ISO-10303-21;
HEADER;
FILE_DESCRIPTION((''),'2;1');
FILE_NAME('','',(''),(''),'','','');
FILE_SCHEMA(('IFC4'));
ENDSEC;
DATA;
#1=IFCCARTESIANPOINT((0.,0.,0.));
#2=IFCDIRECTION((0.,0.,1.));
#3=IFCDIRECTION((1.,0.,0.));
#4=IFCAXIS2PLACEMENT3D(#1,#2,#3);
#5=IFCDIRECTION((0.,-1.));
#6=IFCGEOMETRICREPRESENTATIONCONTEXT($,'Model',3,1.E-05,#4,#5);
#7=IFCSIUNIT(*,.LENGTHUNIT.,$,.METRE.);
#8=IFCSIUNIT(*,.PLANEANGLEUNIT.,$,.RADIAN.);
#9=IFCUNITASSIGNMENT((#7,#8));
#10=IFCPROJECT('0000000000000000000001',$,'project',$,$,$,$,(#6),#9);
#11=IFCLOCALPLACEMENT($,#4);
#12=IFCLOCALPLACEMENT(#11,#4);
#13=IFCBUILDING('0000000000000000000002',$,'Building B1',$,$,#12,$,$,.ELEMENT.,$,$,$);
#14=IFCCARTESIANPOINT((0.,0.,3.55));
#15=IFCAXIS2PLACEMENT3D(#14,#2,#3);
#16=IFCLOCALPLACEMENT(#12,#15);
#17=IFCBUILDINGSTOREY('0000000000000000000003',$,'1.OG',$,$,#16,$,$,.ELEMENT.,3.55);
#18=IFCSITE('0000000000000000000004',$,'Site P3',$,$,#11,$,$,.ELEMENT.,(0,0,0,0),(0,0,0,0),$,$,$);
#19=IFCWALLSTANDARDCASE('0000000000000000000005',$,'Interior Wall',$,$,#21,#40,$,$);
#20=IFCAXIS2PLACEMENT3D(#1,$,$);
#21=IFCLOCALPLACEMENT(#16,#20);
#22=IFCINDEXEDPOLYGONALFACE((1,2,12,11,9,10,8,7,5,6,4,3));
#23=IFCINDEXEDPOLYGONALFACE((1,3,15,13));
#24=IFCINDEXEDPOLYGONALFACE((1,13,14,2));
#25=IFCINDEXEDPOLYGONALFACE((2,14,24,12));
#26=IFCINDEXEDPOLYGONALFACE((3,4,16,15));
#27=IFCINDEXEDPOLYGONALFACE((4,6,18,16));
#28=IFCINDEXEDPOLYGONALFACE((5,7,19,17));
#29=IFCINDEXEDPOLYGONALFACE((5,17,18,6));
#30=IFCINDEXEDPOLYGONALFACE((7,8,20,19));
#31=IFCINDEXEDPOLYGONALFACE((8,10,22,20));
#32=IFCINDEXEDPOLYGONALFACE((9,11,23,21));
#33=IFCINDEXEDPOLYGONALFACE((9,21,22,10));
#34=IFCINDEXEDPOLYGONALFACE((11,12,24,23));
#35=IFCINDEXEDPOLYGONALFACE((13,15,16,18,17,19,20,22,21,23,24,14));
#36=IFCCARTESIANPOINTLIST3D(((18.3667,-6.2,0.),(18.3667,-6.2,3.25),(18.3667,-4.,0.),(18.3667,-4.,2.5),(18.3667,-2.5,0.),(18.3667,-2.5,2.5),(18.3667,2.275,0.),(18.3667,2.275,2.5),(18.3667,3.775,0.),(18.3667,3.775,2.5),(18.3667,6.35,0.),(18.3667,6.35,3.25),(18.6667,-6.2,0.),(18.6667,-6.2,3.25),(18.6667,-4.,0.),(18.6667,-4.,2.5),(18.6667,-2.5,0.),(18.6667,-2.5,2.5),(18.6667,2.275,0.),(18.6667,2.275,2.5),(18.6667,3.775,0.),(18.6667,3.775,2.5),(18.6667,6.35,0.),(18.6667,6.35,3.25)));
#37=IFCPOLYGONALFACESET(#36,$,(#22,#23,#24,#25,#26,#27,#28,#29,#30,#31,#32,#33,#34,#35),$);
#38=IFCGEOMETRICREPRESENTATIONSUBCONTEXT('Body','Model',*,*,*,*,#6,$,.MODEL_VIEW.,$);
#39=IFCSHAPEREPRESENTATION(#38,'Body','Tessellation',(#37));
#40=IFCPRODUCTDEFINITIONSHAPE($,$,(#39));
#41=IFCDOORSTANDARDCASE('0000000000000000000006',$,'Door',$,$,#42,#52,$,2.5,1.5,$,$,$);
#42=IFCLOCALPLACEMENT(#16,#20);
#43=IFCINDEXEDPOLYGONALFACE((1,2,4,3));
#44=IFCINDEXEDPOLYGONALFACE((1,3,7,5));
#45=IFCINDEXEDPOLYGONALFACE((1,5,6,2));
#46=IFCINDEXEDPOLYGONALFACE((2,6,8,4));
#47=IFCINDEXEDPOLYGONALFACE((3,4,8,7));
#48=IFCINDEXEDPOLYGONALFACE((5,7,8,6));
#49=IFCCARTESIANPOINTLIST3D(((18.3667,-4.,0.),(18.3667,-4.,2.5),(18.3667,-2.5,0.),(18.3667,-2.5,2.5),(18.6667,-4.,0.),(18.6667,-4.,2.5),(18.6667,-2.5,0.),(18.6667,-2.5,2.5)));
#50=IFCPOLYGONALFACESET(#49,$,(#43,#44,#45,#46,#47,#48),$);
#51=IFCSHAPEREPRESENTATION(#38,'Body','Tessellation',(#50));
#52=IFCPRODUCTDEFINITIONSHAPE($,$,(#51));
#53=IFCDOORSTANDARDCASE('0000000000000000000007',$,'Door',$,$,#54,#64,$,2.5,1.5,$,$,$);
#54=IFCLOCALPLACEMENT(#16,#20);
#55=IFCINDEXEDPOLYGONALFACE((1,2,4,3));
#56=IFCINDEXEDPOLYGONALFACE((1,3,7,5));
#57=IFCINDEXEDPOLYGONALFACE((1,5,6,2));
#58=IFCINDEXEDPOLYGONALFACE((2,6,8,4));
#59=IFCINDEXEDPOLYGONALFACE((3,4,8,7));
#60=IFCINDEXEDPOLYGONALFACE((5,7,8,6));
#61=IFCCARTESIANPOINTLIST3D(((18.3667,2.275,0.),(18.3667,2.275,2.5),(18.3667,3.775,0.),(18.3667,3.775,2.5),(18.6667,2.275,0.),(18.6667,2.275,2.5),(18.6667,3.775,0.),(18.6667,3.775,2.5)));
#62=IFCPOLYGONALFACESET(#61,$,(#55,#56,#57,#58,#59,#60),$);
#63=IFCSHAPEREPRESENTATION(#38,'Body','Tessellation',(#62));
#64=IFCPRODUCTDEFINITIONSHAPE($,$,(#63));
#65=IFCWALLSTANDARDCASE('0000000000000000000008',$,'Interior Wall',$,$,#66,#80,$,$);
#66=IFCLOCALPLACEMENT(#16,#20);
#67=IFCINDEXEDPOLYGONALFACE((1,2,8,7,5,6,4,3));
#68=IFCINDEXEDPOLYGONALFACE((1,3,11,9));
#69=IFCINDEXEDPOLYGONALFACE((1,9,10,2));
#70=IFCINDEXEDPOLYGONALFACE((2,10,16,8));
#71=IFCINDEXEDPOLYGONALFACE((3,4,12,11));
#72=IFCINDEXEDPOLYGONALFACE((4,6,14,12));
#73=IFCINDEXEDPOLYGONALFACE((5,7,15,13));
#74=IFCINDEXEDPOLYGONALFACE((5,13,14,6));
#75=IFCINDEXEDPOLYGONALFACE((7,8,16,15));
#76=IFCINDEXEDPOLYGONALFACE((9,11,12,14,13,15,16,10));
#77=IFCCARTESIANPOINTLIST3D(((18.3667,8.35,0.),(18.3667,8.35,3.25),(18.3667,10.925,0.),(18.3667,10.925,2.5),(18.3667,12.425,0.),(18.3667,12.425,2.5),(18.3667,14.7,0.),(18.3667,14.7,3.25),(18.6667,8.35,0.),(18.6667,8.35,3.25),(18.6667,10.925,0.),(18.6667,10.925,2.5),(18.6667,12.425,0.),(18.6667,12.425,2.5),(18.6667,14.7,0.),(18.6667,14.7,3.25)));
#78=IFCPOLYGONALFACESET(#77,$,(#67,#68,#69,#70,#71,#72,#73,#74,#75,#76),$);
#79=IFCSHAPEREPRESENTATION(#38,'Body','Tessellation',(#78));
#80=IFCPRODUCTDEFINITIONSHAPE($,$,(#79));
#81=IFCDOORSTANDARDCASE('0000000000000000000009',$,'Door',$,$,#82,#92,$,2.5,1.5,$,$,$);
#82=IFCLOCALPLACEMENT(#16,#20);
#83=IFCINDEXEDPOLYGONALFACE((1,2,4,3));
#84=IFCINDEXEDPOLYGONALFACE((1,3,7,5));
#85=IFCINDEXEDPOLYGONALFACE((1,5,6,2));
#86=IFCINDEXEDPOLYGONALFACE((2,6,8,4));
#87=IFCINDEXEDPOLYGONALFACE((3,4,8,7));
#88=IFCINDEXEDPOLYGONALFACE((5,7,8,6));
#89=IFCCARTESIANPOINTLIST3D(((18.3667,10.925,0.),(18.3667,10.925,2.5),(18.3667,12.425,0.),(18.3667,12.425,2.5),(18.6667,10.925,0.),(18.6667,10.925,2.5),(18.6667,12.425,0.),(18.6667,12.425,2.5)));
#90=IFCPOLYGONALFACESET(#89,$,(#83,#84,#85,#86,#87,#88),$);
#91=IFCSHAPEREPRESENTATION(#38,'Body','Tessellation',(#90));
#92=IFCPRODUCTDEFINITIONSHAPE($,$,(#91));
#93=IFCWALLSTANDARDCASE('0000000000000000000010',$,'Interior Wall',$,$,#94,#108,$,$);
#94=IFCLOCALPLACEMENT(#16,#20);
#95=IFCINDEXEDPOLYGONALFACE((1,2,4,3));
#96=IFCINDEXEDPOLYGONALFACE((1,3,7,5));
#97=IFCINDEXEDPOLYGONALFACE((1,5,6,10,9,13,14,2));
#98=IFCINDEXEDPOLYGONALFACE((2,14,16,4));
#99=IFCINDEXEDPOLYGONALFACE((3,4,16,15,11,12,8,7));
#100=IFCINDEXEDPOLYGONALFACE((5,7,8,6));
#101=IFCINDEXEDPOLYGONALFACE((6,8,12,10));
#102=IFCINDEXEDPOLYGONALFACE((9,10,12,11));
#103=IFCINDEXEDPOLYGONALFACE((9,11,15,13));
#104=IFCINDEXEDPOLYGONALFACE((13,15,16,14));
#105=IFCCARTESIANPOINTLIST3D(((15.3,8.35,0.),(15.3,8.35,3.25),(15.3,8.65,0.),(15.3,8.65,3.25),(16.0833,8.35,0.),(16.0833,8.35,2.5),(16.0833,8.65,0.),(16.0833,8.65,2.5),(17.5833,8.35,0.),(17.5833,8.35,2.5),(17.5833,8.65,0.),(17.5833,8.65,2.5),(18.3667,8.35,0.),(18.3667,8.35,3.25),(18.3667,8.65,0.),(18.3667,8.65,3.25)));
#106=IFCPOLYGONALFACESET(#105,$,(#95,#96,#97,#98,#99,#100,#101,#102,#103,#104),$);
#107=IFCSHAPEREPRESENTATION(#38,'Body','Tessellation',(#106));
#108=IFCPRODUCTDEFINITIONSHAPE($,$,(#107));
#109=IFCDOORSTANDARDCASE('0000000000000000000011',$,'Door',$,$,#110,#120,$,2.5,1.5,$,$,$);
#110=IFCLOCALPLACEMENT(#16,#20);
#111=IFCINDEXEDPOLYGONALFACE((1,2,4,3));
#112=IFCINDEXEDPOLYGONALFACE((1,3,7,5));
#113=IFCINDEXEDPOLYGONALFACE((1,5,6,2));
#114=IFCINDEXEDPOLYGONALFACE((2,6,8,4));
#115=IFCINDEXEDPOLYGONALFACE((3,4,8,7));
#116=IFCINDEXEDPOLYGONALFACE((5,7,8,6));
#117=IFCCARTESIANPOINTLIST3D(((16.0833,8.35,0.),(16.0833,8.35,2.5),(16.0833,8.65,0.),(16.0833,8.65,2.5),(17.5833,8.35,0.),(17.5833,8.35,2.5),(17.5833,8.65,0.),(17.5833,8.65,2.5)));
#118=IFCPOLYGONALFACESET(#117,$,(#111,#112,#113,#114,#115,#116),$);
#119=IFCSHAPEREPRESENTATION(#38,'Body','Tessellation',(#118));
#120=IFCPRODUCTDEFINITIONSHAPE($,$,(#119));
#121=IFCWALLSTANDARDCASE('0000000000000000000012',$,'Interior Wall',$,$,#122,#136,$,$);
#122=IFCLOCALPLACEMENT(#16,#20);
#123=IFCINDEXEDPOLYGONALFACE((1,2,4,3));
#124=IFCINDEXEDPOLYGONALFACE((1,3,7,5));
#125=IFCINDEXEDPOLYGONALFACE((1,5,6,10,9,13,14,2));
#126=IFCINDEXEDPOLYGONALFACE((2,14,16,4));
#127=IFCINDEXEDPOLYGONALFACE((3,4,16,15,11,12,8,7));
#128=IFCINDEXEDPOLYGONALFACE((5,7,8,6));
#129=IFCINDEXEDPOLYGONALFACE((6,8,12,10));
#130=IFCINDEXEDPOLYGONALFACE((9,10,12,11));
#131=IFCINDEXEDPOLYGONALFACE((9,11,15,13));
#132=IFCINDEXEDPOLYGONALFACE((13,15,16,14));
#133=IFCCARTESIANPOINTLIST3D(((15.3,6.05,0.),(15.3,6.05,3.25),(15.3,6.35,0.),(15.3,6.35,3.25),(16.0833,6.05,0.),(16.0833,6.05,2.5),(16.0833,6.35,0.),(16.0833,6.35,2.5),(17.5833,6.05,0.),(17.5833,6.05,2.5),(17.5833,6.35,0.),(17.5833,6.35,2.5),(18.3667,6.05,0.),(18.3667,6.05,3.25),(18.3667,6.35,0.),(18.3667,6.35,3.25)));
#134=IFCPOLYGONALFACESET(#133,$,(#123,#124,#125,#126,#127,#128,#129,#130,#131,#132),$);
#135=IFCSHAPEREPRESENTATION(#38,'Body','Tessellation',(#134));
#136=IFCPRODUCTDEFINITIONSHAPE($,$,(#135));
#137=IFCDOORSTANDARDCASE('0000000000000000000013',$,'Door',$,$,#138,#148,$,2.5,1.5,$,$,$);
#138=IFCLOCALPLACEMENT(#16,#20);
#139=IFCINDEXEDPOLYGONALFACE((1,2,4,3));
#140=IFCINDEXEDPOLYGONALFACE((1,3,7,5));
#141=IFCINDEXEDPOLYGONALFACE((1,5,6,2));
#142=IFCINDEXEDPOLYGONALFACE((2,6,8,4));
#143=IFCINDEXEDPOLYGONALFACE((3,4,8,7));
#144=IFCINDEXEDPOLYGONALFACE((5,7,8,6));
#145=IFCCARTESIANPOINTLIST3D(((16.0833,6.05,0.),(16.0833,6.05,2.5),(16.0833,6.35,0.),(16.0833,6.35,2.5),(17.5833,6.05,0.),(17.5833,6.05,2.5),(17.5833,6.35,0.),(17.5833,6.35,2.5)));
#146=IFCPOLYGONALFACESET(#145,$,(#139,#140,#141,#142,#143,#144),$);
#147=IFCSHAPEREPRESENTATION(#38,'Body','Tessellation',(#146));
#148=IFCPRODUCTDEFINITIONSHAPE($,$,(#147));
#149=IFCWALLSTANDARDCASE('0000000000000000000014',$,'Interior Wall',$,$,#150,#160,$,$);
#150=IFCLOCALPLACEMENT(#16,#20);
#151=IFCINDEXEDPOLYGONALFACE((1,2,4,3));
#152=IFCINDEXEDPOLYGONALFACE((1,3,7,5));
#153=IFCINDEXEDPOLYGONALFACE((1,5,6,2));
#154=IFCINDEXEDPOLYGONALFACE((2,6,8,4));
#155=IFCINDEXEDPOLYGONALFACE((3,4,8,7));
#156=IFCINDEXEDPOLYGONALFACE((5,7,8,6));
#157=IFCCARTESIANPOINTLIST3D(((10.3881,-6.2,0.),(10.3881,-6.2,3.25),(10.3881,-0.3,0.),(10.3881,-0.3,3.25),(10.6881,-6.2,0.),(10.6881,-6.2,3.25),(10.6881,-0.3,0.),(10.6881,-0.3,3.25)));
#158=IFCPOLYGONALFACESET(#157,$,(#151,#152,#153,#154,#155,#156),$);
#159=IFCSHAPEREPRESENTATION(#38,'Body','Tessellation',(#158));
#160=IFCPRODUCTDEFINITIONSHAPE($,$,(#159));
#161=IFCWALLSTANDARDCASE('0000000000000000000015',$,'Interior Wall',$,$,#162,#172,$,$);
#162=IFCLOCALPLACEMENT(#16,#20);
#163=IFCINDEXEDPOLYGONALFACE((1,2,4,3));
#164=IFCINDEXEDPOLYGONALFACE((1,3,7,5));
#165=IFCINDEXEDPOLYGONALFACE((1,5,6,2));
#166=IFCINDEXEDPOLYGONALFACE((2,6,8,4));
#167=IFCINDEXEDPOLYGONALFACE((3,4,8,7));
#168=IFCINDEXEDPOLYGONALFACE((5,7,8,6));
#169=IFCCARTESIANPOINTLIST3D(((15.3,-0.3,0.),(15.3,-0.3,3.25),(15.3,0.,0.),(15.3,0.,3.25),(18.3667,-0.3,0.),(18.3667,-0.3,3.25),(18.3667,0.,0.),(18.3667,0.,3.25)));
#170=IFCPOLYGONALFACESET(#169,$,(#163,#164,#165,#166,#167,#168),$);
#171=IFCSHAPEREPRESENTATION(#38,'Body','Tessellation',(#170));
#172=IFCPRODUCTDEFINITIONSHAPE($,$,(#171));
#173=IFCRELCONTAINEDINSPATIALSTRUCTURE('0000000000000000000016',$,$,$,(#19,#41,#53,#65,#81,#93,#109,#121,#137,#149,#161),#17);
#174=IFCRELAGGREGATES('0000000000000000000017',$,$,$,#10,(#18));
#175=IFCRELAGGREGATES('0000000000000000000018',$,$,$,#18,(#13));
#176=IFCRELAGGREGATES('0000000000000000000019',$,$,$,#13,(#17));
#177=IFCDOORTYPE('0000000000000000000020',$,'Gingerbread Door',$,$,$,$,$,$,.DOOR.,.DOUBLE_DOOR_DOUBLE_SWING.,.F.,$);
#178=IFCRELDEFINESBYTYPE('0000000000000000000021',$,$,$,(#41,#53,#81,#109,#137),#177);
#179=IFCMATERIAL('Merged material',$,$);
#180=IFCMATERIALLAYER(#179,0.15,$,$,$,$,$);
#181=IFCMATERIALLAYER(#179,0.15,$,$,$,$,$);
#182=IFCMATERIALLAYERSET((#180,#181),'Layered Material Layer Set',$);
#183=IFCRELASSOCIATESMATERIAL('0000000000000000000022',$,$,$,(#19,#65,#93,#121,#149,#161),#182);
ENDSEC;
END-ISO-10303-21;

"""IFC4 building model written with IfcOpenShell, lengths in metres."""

from ifc_helpers import new_model, si_unit, direction, frame, origin_with_axes, place, context, subcontext, project, spatial, polyline, outline, extrude, source, transform, mapped, material, layer, layer_set, layer_usage, type_object, element, fill, save


model = new_model("IFC4")

# Units and contexts
model_context = context("Model", 3, precision=1e-05, world=origin_with_axes(), true_north=direction((0.0, -1.0)))
body_context = subcontext(model_context, "Body", "Model", "MODEL_VIEW")
ifc_project = project(units=[si_unit("LENGTHUNIT", "METRE"), si_unit("PLANEANGLEUNIT", "RADIAN")], contexts=[model_context])

# Site, building, storey
site_placement = place(None, origin_with_axes())
site = spatial("IfcSite", under=ifc_project, at=site_placement, Name="Site P3", CompositionType="ELEMENT", RefLatitude=(0, 0, 0, 0), RefLongitude=(0, 0, 0, 0))
building_placement = place(site_placement, origin_with_axes())
building = spatial("IfcBuilding", under=site, at=building_placement, Name="Building B1", CompositionType="ELEMENT")
storey_placement = place(building_placement, frame((0.0, 0.0, 3.55), z_axis=(0.0, 0.0, 1.0), x_axis=(1.0, 0.0, 0.0)))
storey = spatial("IfcBuildingStorey", under=building, at=storey_placement, Name="1.OG", CompositionType="ELEMENT", Elevation=3.55)

# Shared definitions
ifc_material = material(Name="Merged material")

# Wall, openings, doors
ifc_layer_1 = layer(ifc_material, 0.15)
ifc_layer_2 = layer(ifc_material, 0.15)
ifc_layer_set_1 = layer_set([ifc_layer_1, ifc_layer_2], Name="Layered Material Layer Set")
ifc_layer_usage_1 = layer_usage(ifc_layer_set_1, "AXIS2", "POSITIVE", -0.15)
wall_1_placement = place(storey_placement, frame((18.5167, 6.35, 0.0), z_axis=(0.0, 0.0, 1.0), x_axis=(0.0, -1.0, 0.0)))
wall_1 = element("IfcWallStandardCase", 1, at=wall_1_placement, inside=storey, material=ifc_layer_usage_1, Name="Interior Wall", context=body_context, shape_type="SweptSolid", body=[
    extrude(outline(polyline([(0.0, 0.15), (12.55, 0.15), (12.55, -0.15), (0.0, -0.15), (0.0, 0.15)])), origin_with_axes(), (0.0, 0.0, 1.0), 3.25),
])
opening_1_placement = place(wall_1_placement, frame((8.85, 0.0, 0.0), z_axis=(0.0, 0.0, 1.0), x_axis=(1.0, 0.0, 0.0)))
opening_1 = element("IfcOpeningStandardCase", 2, at=opening_1_placement, cuts=wall_1, context=body_context, shape_type="SweptSolid", body=[
    extrude(outline(polyline([(0.0, 0.0), (0.0, 1.5), (2.5, 1.5), (2.5, 0.0), (0.0, 0.0)])), frame((0.0, -0.15, 0.0), z_axis=(0.0, 1.0, 0.0), x_axis=(0.0, 0.0, 1.0)), (0.0, 0.0, 1.0), 0.3),
])
opening_2_placement = place(wall_1_placement, frame((2.575, 0.0, 0.0), z_axis=(0.0, 0.0, 1.0), x_axis=(1.0, 0.0, 0.0)))
opening_2 = element("IfcOpeningStandardCase", 3, at=opening_2_placement, cuts=wall_1, context=body_context, shape_type="SweptSolid", body=[
    extrude(outline(polyline([(0.0, 0.0), (0.0, 1.5), (2.5, 1.5), (2.5, 0.0), (0.0, 0.0)])), frame((0.0, -0.15, 0.0), z_axis=(0.0, 1.0, 0.0), x_axis=(0.0, 0.0, 1.0)), (0.0, 0.0, 1.0), 0.3),
])
door_type = type_object("IfcDoorType", Name="Gingerbread Door", OperationType="DOUBLE_DOOR_DOUBLE_SWING", ParameterTakesPrecedence=False, PredefinedType="DOOR")
shared_shape_1 = source(origin_with_axes(), body_context, "Body", "SweptSolid", [
    extrude(outline(polyline([(0.0, 0.0), (0.0, 1.5), (2.5, 1.5), (2.5, 0.0), (0.0, 0.0)])), frame((0.0, -0.15, 0.0), z_axis=(0.0, 1.0, 0.0), x_axis=(0.0, 0.0, 1.0)), (0.0, 0.0, 1.0), 0.3),
])
door_1_placement = place(opening_1_placement, origin_with_axes())
door_1 = element("IfcDoorStandardCase", 4, at=door_1_placement, inside=storey, type_object=door_type, Name="Door", OverallHeight=2.5, OverallWidth=1.5, context=body_context, shape_type="MappedRepresentation", body=[
    mapped(shared_shape_1, transform((0.0, 0.0, 0.0))),
])
fill(opening_1, door_1)
door_2_placement = place(opening_2_placement, origin_with_axes())
door_2 = element("IfcDoorStandardCase", 5, at=door_2_placement, inside=storey, type_object=door_type, Name="Door", OverallHeight=2.5, OverallWidth=1.5, context=body_context, shape_type="MappedRepresentation", body=[
    mapped(shared_shape_1, transform((0.0, 0.0, 0.0))),
])
fill(opening_2, door_2)

# Walls, openings, doors
wall_2_placement = place(storey_placement, frame((18.5167, 14.7, 0.0), z_axis=(0.0, 0.0, 1.0), x_axis=(0.0, -1.0, 0.0)))
wall_2 = element("IfcWallStandardCase", 6, at=wall_2_placement, inside=storey, material=ifc_layer_usage_1, Name="Interior Wall", context=body_context, shape_type="SweptSolid", body=[
    extrude(outline(polyline([(0.0, 0.15), (6.35, 0.15), (6.35, -0.15), (0.0, -0.15), (0.0, 0.15)])), origin_with_axes(), (0.0, 0.0, 1.0), 3.25),
])
opening_3_placement = place(wall_2_placement, frame((2.275, 0.0, 0.0), z_axis=(0.0, 0.0, 1.0), x_axis=(1.0, 0.0, 0.0)))
opening_3 = element("IfcOpeningStandardCase", 7, at=opening_3_placement, cuts=wall_2, context=body_context, shape_type="SweptSolid", body=[
    extrude(outline(polyline([(0.0, 0.0), (0.0, 1.5), (2.5, 1.5), (2.5, 0.0), (0.0, 0.0)])), frame((0.0, -0.15, 0.0), z_axis=(0.0, 1.0, 0.0), x_axis=(0.0, 0.0, 1.0)), (0.0, 0.0, 1.0), 0.3),
])
door_3_placement = place(opening_3_placement, origin_with_axes())
door_3 = element("IfcDoorStandardCase", 8, at=door_3_placement, inside=storey, type_object=door_type, Name="Door", OverallHeight=2.5, OverallWidth=1.5, context=body_context, shape_type="MappedRepresentation", body=[
    mapped(shared_shape_1, transform((0.0, 0.0, 0.0))),
])
fill(opening_3, door_3)
wall_3_placement = place(storey_placement, frame((15.3, 8.5, 0.0), z_axis=(0.0, 0.0, 1.0), x_axis=(1.0, 0.0, 0.0)))
wall_3 = element("IfcWallStandardCase", 9, at=wall_3_placement, inside=storey, material=ifc_layer_usage_1, Name="Interior Wall", context=body_context, shape_type="SweptSolid", body=[
    extrude(outline(polyline([(0.0, 0.15), (3.0667, 0.15), (3.0667, -0.15), (0.0, -0.15), (0.0, 0.15)])), origin_with_axes(), (0.0, 0.0, 1.0), 3.25),
])
opening_4_placement = place(wall_3_placement, frame((0.7833, 0.0, 0.0), z_axis=(0.0, 0.0, 1.0), x_axis=(1.0, 0.0, 0.0)))
opening_4 = element("IfcOpeningStandardCase", 10, at=opening_4_placement, cuts=wall_3, context=body_context, shape_type="SweptSolid", body=[
    extrude(outline(polyline([(0.0, 0.0), (0.0, 1.5), (2.5, 1.5), (2.5, 0.0), (0.0, 0.0)])), frame((0.0, -0.15, 0.0), z_axis=(0.0, 1.0, 0.0), x_axis=(0.0, 0.0, 1.0)), (0.0, 0.0, 1.0), 0.3),
])
door_4_placement = place(opening_4_placement, origin_with_axes())
door_4 = element("IfcDoorStandardCase", 11, at=door_4_placement, inside=storey, type_object=door_type, Name="Door", OverallHeight=2.5, OverallWidth=1.5, context=body_context, shape_type="MappedRepresentation", body=[
    mapped(shared_shape_1, transform((0.0, 0.0, 0.0))),
])
fill(opening_4, door_4)
wall_4_placement = place(storey_placement, frame((15.3, 6.2, 0.0), z_axis=(0.0, 0.0, 1.0), x_axis=(1.0, 0.0, 0.0)))
wall_4 = element("IfcWallStandardCase", 12, at=wall_4_placement, inside=storey, material=ifc_layer_usage_1, Name="Interior Wall", context=body_context, shape_type="SweptSolid", body=[
    extrude(outline(polyline([(0.0, 0.15), (3.0667, 0.15), (3.0667, -0.15), (0.0, -0.15), (0.0, 0.15)])), origin_with_axes(), (0.0, 0.0, 1.0), 3.25),
])
opening_5_placement = place(wall_4_placement, frame((0.7833, 0.0, 0.0), z_axis=(0.0, 0.0, 1.0), x_axis=(1.0, 0.0, 0.0)))
opening_5 = element("IfcOpeningStandardCase", 13, at=opening_5_placement, cuts=wall_4, context=body_context, shape_type="SweptSolid", body=[
    extrude(outline(polyline([(0.0, 0.0), (0.0, 1.5), (2.5, 1.5), (2.5, 0.0), (0.0, 0.0)])), frame((0.0, -0.15, 0.0), z_axis=(0.0, 1.0, 0.0), x_axis=(0.0, 0.0, 1.0)), (0.0, 0.0, 1.0), 0.3),
])
door_5_placement = place(opening_5_placement, origin_with_axes())
door_5 = element("IfcDoorStandardCase", 14, at=door_5_placement, inside=storey, type_object=door_type, Name="Door", OverallHeight=2.5, OverallWidth=1.5, context=body_context, shape_type="MappedRepresentation", body=[
    mapped(shared_shape_1, transform((0.0, 0.0, 0.0))),
])
fill(opening_5, door_5)

# Walls
wall_5_placement = place(storey_placement, frame((10.5381, -0.3, 0.0), z_axis=(0.0, 0.0, 1.0), x_axis=(0.0, -1.0, 0.0)))
element("IfcWallStandardCase", 15, at=wall_5_placement, inside=storey, material=ifc_layer_usage_1, Name="Interior Wall", context=body_context, shape_type="SweptSolid", body=[
    extrude(outline(polyline([(0.0, 0.15), (5.9, 0.15), (5.9, -0.15), (0.0, -0.15), (0.0, 0.15)])), origin_with_axes(), (0.0, 0.0, 1.0), 3.25),
])
wall_6_placement = place(storey_placement, frame((15.3, -0.15, 0.0), z_axis=(0.0, 0.0, 1.0), x_axis=(1.0, 0.0, 0.0)))
element("IfcWallStandardCase", 16, at=wall_6_placement, inside=storey, material=ifc_layer_usage_1, Name="Interior Wall", context=body_context, shape_type="SweptSolid", body=[
    extrude(outline(polyline([(0.0, 0.15), (3.0667, 0.15), (3.0667, -0.15), (0.0, -0.15), (0.0, 0.15)])), origin_with_axes(), (0.0, 0.0, 1.0), 3.25),
])

save(model, "model.ifc")
